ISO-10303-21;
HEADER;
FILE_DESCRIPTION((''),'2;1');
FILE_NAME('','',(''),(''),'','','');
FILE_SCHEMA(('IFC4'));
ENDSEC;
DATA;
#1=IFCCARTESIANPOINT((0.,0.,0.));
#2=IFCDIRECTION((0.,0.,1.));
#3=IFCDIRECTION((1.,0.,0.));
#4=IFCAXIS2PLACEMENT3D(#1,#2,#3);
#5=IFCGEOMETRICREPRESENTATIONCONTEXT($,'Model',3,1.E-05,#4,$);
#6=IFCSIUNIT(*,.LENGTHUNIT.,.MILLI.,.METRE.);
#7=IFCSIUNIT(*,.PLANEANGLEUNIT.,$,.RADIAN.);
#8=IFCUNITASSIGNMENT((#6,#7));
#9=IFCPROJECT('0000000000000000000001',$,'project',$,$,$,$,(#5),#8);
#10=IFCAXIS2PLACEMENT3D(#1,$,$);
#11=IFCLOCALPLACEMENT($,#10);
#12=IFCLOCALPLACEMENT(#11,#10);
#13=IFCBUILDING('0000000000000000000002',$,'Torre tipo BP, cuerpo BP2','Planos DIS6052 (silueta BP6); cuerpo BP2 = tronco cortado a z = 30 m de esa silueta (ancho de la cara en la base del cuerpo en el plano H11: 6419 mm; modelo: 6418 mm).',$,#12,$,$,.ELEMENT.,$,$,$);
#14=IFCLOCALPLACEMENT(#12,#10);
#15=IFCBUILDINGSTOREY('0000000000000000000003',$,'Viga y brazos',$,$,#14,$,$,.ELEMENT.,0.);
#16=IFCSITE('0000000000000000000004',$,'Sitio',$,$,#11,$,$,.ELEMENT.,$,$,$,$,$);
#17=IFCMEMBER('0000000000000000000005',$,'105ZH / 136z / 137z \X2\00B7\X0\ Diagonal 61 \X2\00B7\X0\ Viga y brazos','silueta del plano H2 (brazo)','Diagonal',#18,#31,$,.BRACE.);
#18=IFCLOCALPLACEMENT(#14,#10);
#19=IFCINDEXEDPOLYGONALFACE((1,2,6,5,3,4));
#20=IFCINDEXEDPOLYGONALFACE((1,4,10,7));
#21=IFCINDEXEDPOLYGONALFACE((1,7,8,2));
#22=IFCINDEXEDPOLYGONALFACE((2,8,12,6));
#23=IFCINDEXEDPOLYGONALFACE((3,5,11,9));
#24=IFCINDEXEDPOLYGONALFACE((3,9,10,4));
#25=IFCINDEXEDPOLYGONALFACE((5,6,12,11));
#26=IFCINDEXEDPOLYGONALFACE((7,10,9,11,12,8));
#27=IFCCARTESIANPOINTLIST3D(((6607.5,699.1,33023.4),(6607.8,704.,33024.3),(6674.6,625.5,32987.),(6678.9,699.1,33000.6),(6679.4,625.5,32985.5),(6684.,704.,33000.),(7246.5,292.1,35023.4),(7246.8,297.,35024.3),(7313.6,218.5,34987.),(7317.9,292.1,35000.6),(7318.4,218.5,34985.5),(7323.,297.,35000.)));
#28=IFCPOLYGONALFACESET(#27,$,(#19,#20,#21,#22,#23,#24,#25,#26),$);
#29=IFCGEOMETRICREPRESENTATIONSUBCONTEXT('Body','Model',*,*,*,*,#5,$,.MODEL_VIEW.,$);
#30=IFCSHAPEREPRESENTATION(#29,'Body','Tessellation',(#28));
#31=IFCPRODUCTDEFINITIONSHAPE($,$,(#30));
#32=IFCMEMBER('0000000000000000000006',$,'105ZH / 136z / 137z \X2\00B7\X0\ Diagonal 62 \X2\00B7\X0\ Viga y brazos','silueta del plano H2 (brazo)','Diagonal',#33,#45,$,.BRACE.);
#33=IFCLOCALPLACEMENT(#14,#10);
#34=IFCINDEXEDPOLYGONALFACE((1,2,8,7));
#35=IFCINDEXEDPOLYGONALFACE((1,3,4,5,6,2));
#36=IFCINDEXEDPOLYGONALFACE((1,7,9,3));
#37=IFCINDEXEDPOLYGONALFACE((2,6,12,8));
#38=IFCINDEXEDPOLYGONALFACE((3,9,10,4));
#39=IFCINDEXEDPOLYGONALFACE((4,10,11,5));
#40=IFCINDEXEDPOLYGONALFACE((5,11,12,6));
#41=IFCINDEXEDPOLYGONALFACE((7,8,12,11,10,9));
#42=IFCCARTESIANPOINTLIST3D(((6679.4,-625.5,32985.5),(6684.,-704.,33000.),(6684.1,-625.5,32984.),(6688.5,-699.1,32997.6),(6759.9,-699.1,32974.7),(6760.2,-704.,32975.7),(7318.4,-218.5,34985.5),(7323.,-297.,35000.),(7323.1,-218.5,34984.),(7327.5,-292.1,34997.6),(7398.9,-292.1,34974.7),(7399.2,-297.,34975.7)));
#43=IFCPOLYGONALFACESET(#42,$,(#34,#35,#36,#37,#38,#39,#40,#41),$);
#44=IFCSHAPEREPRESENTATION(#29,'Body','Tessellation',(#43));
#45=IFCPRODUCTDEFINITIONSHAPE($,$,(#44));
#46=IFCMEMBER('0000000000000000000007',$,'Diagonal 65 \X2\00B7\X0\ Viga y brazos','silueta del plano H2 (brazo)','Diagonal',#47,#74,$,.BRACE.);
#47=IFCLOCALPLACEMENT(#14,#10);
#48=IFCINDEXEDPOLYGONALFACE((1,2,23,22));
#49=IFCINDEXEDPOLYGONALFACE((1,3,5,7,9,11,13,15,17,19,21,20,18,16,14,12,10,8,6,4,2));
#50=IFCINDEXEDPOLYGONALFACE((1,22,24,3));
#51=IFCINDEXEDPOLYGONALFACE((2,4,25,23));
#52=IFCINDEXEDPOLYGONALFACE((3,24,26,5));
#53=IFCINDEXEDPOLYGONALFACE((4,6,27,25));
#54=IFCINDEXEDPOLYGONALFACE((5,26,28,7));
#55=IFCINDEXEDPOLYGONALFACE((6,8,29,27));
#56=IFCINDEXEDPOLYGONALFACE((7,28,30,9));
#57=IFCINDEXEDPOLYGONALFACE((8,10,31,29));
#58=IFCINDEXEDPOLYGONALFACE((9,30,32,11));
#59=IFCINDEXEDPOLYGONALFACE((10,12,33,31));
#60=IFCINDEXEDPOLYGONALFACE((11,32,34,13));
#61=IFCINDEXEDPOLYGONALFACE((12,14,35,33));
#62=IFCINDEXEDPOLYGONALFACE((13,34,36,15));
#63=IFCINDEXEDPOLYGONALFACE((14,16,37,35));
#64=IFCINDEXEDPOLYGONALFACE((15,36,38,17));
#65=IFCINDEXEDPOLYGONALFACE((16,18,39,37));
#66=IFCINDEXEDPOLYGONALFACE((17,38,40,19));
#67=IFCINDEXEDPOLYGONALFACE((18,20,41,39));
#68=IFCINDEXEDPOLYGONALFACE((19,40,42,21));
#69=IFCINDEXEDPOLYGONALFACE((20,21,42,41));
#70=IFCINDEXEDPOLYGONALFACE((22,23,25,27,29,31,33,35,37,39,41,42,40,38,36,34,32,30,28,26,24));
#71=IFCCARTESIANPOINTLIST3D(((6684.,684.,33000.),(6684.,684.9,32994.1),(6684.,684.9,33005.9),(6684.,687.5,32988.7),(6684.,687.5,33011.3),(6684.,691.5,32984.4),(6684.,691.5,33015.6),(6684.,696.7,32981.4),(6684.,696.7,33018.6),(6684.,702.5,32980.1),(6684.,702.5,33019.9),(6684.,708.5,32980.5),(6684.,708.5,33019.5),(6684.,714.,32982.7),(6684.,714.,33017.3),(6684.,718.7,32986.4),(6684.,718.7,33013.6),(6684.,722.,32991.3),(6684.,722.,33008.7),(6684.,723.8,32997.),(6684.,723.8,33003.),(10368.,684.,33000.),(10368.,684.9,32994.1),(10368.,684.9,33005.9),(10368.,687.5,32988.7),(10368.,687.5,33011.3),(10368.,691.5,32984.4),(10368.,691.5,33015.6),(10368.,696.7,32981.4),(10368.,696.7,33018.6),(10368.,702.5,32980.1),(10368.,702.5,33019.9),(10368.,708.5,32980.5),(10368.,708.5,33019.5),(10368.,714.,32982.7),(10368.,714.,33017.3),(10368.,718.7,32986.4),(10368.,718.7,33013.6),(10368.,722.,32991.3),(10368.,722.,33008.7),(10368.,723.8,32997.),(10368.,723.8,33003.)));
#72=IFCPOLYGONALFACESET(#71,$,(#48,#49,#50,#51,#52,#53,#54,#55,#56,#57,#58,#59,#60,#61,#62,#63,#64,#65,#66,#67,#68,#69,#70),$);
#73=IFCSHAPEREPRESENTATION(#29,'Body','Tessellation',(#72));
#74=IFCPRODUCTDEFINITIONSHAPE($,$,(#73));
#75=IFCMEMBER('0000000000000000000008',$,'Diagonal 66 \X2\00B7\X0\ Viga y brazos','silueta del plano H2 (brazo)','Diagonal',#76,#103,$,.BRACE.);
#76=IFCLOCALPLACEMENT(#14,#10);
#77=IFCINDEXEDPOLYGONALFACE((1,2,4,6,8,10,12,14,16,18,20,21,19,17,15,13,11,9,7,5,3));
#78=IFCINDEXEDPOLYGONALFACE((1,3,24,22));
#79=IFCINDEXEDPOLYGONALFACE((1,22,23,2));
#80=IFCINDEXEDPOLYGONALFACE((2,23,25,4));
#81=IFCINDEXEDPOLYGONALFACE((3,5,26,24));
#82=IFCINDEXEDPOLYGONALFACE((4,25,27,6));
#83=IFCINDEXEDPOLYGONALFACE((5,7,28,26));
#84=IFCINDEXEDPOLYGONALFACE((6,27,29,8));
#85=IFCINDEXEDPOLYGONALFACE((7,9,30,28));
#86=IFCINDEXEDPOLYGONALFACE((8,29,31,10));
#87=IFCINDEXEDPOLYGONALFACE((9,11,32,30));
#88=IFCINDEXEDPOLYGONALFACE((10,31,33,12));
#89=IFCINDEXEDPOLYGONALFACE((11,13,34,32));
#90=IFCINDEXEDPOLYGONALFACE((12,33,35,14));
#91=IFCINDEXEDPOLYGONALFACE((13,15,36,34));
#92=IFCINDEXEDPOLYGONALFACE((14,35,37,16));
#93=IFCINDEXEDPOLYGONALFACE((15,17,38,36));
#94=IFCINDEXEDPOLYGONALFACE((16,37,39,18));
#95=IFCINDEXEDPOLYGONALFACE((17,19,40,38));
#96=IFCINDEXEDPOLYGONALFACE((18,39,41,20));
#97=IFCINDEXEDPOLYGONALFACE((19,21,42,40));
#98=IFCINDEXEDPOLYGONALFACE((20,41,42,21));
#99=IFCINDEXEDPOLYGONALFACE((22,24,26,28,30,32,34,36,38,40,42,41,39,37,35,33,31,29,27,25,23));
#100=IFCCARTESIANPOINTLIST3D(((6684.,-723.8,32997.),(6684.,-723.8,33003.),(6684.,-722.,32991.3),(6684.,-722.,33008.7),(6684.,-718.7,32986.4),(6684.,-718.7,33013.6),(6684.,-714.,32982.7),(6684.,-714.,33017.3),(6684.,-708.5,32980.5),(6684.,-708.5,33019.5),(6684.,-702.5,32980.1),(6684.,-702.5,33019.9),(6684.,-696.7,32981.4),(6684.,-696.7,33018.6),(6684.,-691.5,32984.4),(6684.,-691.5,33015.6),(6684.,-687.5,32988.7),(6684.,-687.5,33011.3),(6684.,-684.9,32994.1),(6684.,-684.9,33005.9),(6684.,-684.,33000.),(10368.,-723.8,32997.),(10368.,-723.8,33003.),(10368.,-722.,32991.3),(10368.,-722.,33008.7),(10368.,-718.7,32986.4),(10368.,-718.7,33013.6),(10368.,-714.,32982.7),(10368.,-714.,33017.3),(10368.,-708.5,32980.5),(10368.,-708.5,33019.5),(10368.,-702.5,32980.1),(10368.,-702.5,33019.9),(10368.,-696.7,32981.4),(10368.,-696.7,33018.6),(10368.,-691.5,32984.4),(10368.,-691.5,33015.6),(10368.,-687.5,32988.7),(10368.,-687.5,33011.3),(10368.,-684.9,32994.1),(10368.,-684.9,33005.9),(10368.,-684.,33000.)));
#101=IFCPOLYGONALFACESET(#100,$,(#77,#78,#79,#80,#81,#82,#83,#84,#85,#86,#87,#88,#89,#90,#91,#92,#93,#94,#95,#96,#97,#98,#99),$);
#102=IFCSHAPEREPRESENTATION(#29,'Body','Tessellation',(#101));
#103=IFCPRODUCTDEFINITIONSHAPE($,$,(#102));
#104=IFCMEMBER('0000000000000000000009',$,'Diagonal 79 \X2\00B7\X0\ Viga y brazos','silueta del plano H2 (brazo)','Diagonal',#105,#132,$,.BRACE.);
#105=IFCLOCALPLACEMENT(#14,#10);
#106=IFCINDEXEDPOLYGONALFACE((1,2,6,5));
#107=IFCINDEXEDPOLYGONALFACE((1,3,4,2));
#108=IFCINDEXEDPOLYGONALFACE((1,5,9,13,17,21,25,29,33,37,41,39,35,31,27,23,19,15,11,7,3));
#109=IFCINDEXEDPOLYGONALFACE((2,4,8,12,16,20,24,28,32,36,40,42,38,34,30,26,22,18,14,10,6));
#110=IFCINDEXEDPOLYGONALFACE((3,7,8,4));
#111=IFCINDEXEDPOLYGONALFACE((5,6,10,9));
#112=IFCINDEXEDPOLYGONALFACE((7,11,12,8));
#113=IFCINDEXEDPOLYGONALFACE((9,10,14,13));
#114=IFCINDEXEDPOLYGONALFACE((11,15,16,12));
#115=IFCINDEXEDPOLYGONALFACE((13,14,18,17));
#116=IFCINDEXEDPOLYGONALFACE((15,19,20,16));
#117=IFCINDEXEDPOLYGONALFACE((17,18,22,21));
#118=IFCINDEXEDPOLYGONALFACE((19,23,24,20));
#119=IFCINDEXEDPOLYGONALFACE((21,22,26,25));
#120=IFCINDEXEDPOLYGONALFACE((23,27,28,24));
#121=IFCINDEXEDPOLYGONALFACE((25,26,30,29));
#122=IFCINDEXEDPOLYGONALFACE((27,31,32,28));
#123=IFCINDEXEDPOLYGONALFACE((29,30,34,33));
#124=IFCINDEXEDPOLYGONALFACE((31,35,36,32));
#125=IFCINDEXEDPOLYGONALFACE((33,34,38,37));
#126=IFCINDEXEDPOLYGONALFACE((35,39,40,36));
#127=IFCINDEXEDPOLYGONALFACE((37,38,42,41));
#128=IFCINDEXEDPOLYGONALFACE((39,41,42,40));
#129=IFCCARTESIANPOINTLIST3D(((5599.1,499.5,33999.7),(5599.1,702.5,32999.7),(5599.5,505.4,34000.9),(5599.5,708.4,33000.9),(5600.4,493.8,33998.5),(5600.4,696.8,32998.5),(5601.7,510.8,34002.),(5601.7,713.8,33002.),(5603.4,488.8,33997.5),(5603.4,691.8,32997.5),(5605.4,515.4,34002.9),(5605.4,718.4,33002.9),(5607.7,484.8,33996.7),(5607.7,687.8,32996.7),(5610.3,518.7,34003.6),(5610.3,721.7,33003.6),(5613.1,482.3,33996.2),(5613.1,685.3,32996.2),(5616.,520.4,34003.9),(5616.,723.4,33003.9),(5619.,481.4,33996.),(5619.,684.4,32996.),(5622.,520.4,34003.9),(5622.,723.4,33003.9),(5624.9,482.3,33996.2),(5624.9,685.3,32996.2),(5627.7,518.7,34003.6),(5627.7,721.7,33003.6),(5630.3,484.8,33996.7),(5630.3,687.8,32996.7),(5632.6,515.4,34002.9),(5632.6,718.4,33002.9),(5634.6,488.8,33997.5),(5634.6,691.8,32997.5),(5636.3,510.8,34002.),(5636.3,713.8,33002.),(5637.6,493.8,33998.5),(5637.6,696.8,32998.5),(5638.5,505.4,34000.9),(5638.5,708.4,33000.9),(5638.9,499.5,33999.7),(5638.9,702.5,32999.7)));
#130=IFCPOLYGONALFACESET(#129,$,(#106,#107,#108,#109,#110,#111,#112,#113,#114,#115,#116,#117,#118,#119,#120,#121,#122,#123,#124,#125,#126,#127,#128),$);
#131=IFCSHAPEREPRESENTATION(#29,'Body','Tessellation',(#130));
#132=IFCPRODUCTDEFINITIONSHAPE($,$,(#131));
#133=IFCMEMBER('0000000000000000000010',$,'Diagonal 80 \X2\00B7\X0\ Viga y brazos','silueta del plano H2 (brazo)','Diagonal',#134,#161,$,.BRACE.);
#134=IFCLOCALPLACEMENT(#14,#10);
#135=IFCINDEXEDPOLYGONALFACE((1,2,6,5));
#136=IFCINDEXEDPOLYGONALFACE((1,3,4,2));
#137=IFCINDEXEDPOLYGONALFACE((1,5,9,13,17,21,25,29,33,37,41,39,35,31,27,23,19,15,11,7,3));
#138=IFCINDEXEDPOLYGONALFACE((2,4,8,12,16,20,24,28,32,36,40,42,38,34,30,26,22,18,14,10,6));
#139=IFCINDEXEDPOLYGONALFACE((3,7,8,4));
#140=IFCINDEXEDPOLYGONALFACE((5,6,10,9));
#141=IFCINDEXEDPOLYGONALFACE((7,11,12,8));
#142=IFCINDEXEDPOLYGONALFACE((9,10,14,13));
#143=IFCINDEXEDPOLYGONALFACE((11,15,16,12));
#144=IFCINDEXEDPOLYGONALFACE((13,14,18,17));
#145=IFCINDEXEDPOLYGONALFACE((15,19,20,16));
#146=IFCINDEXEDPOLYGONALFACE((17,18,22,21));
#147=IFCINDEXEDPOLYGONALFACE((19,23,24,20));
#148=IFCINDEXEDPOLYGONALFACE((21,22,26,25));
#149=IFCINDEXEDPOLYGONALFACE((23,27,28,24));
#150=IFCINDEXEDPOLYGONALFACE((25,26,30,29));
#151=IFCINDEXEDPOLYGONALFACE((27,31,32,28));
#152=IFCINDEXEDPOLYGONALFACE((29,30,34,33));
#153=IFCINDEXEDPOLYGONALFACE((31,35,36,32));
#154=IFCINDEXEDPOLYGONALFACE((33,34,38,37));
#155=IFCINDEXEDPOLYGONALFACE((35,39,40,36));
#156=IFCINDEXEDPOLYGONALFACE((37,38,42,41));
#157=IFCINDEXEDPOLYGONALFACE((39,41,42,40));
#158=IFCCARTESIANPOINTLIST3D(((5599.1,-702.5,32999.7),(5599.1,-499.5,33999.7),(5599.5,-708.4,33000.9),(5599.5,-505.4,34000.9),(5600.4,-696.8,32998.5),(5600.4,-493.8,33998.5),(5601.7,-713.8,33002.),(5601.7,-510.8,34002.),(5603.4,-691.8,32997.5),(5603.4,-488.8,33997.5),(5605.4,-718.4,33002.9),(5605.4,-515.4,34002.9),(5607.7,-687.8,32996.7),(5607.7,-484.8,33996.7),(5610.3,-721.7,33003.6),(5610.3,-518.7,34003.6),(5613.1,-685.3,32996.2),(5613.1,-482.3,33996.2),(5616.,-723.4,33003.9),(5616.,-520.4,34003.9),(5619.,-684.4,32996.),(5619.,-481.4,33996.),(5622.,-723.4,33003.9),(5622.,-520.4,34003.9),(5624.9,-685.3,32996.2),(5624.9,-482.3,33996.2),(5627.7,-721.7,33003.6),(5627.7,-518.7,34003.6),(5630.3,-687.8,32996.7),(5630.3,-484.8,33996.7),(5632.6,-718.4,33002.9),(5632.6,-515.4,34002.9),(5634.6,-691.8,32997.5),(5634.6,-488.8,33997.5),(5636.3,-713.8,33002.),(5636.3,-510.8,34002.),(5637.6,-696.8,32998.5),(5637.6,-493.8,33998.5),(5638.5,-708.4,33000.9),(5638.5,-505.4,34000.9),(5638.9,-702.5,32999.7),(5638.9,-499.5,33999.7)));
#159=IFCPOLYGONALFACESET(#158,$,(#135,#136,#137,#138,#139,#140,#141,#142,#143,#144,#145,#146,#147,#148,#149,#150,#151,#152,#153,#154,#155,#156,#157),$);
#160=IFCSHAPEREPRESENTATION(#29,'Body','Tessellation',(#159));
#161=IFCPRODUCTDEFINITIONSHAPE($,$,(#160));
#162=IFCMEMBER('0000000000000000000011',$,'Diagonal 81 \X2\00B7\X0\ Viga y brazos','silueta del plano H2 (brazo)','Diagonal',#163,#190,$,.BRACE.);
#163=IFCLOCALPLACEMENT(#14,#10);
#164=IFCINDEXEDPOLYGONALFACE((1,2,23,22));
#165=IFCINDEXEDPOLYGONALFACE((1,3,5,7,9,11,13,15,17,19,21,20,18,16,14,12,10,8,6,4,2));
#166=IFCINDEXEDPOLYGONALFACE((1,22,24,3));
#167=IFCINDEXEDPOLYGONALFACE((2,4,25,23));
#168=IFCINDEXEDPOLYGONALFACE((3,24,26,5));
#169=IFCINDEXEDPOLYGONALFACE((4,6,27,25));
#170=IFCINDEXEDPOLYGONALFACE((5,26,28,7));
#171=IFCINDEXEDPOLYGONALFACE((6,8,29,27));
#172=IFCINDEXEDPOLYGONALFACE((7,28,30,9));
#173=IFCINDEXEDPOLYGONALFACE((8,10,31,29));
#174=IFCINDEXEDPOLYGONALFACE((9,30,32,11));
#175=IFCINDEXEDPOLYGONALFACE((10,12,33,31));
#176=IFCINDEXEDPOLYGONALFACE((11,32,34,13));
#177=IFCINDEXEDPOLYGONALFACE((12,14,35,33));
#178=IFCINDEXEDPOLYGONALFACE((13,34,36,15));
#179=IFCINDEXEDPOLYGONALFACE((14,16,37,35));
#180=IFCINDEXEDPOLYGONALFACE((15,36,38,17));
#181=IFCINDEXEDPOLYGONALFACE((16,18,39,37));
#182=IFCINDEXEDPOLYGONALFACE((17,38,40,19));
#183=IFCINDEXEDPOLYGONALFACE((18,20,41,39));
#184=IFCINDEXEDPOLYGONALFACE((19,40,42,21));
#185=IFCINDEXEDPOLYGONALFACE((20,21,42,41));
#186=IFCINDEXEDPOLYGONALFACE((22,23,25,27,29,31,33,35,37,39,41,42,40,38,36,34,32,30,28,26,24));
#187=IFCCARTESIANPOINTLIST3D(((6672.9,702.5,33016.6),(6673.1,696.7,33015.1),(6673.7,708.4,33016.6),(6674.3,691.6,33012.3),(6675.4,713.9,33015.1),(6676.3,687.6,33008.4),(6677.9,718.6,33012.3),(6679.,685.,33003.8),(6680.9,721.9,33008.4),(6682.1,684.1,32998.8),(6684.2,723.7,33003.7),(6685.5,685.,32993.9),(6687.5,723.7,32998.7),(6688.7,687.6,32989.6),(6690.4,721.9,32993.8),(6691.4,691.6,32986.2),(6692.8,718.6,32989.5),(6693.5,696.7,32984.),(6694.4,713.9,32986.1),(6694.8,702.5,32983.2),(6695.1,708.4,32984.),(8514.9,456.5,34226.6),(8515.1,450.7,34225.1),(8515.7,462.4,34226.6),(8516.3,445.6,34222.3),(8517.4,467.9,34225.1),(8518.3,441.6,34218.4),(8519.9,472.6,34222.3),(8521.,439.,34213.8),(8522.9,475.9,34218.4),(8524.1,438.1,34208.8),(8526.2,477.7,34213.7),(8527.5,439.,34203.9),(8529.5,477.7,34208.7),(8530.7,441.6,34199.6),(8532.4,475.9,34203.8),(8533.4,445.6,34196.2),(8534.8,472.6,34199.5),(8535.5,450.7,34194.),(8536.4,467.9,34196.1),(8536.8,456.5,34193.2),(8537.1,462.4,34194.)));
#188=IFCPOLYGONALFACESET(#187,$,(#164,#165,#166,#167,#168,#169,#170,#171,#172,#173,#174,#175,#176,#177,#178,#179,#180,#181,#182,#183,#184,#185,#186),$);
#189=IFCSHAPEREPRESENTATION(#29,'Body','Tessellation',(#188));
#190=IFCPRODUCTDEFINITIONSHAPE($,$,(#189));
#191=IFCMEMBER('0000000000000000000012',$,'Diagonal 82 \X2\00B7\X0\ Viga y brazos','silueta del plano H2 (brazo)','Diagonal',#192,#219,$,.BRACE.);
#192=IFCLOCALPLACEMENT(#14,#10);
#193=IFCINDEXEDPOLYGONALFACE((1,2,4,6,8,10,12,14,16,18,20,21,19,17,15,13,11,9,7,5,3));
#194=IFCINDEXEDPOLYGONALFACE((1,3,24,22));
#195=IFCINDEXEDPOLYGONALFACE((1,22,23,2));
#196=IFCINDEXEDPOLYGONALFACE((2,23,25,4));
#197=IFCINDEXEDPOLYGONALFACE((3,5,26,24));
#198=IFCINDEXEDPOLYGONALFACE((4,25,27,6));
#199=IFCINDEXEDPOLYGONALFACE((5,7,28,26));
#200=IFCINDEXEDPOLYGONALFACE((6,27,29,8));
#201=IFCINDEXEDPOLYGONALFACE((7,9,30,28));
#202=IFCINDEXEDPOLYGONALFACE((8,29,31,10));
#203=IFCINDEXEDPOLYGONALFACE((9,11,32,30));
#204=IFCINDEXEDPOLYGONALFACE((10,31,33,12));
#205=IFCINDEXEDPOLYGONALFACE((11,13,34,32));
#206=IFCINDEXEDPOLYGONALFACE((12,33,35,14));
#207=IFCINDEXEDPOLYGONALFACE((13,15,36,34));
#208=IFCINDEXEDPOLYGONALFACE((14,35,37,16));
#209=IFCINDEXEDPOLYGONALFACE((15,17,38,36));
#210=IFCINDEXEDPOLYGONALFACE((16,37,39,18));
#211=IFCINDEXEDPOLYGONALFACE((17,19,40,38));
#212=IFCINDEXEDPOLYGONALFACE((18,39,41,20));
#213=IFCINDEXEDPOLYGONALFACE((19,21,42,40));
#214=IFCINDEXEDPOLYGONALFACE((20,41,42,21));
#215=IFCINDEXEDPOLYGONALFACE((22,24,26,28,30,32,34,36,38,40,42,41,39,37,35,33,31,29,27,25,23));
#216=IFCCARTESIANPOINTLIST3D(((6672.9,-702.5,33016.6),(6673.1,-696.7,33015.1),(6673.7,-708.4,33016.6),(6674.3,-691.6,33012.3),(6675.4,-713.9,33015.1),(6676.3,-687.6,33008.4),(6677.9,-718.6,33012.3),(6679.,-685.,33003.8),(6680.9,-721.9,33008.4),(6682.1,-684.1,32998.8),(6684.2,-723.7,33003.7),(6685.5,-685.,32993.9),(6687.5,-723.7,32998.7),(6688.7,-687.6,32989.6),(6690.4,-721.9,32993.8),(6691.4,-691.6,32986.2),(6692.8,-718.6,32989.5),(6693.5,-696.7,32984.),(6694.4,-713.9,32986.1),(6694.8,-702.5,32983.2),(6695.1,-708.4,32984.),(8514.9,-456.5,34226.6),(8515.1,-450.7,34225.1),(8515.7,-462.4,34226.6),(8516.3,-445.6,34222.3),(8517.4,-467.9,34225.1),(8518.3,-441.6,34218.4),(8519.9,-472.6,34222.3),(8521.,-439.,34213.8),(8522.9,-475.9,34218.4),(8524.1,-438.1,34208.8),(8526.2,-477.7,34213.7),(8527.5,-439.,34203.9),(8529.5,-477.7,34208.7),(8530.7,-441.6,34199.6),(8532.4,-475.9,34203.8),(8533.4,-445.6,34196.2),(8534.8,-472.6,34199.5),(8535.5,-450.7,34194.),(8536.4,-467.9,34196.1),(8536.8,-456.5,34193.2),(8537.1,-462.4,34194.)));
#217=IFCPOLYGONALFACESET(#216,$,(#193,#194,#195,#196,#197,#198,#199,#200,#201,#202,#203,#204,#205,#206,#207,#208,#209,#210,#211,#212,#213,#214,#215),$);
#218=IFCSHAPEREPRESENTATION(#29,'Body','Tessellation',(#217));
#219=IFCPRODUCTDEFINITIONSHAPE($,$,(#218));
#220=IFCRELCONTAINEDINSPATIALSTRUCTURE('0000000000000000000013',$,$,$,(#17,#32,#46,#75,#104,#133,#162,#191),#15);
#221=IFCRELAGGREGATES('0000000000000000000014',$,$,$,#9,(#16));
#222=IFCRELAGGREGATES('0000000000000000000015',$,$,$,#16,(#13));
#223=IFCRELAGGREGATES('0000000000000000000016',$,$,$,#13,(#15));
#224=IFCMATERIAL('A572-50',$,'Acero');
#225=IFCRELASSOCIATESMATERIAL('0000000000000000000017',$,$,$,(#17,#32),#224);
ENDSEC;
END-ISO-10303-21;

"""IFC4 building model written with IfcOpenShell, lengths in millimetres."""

from ifc_helpers import new_model, si_unit, frame, frame_2d, origin, origin_with_axes, place, context, subcontext, project, spatial, circle, l_section, extrude, material, element, save


model = new_model("IFC4")

# Units and contexts
model_context = context("Model", 3, precision=1e-05, world=origin_with_axes())
body_context = subcontext(model_context, "Body", "Model", "MODEL_VIEW")
ifc_project = project(units=[si_unit("LENGTHUNIT", "METRE", prefix="MILLI"), si_unit("PLANEANGLEUNIT", "RADIAN")], contexts=[model_context])

# Site, building, storey
site_placement = place(None, origin())
site = spatial("IfcSite", under=ifc_project, at=site_placement, Name="Sitio", CompositionType="ELEMENT")
building_placement = place(site_placement, origin())
building = spatial("IfcBuilding", under=site, at=building_placement, Name="Torre tipo BP, cuerpo BP2", Description="Planos DIS6052 (silueta BP6); cuerpo BP2 = tronco cortado a z = 30 m de esa silueta (ancho de la cara en la base del cuerpo en el plano H11: 6419 mm; modelo: 6418 mm).", CompositionType="ELEMENT")
storey_placement = place(building_placement, origin())
storey = spatial("IfcBuildingStorey", under=building, at=storey_placement, Name="Viga y brazos", CompositionType="ELEMENT", Elevation=0.0)

# Members
ifc_material_1 = material(Name="A572-50", Category="Acero")
for number, where, z_axis, x_axis, name in (
    (1, (7323.0, 297.0, 35000.0), (-0.298782, 0.190304, -0.935154), (-0.057918, -0.981725, -0.181276), "105ZH / 136z / 137z · Diagonal 61 · Viga y brazos"),
    (2, (7323.0, -297.0, 35000.0), (-0.298782, -0.190304, -0.935154), (-0.057918, 0.981725, -0.181276), "105ZH / 136z / 137z · Diagonal 62 · Viga y brazos"),
):
    element("IfcMember", number, at=place(storey_placement, frame(where, z_axis=z_axis, x_axis=x_axis)), inside=storey, material=ifc_material_1, Name=name, Description="silueta del plano H2 (brazo)", ObjectType="Diagonal", PredefinedType="BRACE", context=body_context, shape_type="SweptSolid", body=[
        extrude(l_section(Depth=80.0, Width=80.0, Thickness=5.0, at=frame_2d((40.0, 40.0))), None, (0.0, 0.0, 1.0), 2138.7),
    ])
for number, where, z_axis, x_axis, name in (
    (3, (6684.0, 704.0, 33000.0), (1.0, 0.0, 0.0), (0.0, -1.0, 0.0), "Diagonal 65 · Viga y brazos"),
    (4, (6684.0, -704.0, 33000.0), (1.0, 0.0, 0.0), (0.0, 1.0, 0.0), "Diagonal 66 · Viga y brazos"),
):
    element("IfcMember", number, at=place(storey_placement, frame(where, z_axis=z_axis, x_axis=x_axis)), inside=storey, Name=name, Description="silueta del plano H2 (brazo)", ObjectType="Diagonal", PredefinedType="BRACE", context=body_context, shape_type="SweptSolid", body=[
        extrude(circle(Radius=20.0), None, (0.0, 0.0, 1.0), 3684.0),
    ])
for number, where, z_axis, x_axis, name in (
    (5, (5619.0, 704.0, 33000.0), (0.0, -0.198942, 0.980011), (0.0, -0.980011, -0.198942), "Diagonal 79 · Viga y brazos"),
    (6, (5619.0, -704.0, 33000.0), (0.0, 0.198942, 0.980011), (0.0, 0.980011, -0.198942), "Diagonal 80 · Viga y brazos"),
):
    element("IfcMember", number, at=place(storey_placement, frame(where, z_axis=z_axis, x_axis=x_axis)), inside=storey, Name=name, Description="silueta del plano H2 (brazo)", ObjectType="Diagonal", PredefinedType="BRACE", context=body_context, shape_type="SweptSolid", body=[
        extrude(circle(Radius=20.0), None, (0.0, 0.0, 1.0), 1020.4),
    ])
for number, where, z_axis, x_axis, name in (
    (7, (6684.0, 704.0, 33000.0), (0.830642, -0.110933, 0.545644), (-0.092718, -0.993828, -0.060906), "Diagonal 81 · Viga y brazos"),
    (8, (6684.0, -704.0, 33000.0), (0.830642, 0.110933, 0.545644), (-0.092718, 0.993828, -0.060906), "Diagonal 82 · Viga y brazos"),
):
    element("IfcMember", number, at=place(storey_placement, frame(where, z_axis=z_axis, x_axis=x_axis)), inside=storey, Name=name, Description="silueta del plano H2 (brazo)", ObjectType="Diagonal", PredefinedType="BRACE", context=body_context, shape_type="SweptSolid", body=[
        extrude(circle(Radius=20.0), None, (0.0, 0.0, 1.0), 2217.6),
    ])

save(model, "model.ifc")
